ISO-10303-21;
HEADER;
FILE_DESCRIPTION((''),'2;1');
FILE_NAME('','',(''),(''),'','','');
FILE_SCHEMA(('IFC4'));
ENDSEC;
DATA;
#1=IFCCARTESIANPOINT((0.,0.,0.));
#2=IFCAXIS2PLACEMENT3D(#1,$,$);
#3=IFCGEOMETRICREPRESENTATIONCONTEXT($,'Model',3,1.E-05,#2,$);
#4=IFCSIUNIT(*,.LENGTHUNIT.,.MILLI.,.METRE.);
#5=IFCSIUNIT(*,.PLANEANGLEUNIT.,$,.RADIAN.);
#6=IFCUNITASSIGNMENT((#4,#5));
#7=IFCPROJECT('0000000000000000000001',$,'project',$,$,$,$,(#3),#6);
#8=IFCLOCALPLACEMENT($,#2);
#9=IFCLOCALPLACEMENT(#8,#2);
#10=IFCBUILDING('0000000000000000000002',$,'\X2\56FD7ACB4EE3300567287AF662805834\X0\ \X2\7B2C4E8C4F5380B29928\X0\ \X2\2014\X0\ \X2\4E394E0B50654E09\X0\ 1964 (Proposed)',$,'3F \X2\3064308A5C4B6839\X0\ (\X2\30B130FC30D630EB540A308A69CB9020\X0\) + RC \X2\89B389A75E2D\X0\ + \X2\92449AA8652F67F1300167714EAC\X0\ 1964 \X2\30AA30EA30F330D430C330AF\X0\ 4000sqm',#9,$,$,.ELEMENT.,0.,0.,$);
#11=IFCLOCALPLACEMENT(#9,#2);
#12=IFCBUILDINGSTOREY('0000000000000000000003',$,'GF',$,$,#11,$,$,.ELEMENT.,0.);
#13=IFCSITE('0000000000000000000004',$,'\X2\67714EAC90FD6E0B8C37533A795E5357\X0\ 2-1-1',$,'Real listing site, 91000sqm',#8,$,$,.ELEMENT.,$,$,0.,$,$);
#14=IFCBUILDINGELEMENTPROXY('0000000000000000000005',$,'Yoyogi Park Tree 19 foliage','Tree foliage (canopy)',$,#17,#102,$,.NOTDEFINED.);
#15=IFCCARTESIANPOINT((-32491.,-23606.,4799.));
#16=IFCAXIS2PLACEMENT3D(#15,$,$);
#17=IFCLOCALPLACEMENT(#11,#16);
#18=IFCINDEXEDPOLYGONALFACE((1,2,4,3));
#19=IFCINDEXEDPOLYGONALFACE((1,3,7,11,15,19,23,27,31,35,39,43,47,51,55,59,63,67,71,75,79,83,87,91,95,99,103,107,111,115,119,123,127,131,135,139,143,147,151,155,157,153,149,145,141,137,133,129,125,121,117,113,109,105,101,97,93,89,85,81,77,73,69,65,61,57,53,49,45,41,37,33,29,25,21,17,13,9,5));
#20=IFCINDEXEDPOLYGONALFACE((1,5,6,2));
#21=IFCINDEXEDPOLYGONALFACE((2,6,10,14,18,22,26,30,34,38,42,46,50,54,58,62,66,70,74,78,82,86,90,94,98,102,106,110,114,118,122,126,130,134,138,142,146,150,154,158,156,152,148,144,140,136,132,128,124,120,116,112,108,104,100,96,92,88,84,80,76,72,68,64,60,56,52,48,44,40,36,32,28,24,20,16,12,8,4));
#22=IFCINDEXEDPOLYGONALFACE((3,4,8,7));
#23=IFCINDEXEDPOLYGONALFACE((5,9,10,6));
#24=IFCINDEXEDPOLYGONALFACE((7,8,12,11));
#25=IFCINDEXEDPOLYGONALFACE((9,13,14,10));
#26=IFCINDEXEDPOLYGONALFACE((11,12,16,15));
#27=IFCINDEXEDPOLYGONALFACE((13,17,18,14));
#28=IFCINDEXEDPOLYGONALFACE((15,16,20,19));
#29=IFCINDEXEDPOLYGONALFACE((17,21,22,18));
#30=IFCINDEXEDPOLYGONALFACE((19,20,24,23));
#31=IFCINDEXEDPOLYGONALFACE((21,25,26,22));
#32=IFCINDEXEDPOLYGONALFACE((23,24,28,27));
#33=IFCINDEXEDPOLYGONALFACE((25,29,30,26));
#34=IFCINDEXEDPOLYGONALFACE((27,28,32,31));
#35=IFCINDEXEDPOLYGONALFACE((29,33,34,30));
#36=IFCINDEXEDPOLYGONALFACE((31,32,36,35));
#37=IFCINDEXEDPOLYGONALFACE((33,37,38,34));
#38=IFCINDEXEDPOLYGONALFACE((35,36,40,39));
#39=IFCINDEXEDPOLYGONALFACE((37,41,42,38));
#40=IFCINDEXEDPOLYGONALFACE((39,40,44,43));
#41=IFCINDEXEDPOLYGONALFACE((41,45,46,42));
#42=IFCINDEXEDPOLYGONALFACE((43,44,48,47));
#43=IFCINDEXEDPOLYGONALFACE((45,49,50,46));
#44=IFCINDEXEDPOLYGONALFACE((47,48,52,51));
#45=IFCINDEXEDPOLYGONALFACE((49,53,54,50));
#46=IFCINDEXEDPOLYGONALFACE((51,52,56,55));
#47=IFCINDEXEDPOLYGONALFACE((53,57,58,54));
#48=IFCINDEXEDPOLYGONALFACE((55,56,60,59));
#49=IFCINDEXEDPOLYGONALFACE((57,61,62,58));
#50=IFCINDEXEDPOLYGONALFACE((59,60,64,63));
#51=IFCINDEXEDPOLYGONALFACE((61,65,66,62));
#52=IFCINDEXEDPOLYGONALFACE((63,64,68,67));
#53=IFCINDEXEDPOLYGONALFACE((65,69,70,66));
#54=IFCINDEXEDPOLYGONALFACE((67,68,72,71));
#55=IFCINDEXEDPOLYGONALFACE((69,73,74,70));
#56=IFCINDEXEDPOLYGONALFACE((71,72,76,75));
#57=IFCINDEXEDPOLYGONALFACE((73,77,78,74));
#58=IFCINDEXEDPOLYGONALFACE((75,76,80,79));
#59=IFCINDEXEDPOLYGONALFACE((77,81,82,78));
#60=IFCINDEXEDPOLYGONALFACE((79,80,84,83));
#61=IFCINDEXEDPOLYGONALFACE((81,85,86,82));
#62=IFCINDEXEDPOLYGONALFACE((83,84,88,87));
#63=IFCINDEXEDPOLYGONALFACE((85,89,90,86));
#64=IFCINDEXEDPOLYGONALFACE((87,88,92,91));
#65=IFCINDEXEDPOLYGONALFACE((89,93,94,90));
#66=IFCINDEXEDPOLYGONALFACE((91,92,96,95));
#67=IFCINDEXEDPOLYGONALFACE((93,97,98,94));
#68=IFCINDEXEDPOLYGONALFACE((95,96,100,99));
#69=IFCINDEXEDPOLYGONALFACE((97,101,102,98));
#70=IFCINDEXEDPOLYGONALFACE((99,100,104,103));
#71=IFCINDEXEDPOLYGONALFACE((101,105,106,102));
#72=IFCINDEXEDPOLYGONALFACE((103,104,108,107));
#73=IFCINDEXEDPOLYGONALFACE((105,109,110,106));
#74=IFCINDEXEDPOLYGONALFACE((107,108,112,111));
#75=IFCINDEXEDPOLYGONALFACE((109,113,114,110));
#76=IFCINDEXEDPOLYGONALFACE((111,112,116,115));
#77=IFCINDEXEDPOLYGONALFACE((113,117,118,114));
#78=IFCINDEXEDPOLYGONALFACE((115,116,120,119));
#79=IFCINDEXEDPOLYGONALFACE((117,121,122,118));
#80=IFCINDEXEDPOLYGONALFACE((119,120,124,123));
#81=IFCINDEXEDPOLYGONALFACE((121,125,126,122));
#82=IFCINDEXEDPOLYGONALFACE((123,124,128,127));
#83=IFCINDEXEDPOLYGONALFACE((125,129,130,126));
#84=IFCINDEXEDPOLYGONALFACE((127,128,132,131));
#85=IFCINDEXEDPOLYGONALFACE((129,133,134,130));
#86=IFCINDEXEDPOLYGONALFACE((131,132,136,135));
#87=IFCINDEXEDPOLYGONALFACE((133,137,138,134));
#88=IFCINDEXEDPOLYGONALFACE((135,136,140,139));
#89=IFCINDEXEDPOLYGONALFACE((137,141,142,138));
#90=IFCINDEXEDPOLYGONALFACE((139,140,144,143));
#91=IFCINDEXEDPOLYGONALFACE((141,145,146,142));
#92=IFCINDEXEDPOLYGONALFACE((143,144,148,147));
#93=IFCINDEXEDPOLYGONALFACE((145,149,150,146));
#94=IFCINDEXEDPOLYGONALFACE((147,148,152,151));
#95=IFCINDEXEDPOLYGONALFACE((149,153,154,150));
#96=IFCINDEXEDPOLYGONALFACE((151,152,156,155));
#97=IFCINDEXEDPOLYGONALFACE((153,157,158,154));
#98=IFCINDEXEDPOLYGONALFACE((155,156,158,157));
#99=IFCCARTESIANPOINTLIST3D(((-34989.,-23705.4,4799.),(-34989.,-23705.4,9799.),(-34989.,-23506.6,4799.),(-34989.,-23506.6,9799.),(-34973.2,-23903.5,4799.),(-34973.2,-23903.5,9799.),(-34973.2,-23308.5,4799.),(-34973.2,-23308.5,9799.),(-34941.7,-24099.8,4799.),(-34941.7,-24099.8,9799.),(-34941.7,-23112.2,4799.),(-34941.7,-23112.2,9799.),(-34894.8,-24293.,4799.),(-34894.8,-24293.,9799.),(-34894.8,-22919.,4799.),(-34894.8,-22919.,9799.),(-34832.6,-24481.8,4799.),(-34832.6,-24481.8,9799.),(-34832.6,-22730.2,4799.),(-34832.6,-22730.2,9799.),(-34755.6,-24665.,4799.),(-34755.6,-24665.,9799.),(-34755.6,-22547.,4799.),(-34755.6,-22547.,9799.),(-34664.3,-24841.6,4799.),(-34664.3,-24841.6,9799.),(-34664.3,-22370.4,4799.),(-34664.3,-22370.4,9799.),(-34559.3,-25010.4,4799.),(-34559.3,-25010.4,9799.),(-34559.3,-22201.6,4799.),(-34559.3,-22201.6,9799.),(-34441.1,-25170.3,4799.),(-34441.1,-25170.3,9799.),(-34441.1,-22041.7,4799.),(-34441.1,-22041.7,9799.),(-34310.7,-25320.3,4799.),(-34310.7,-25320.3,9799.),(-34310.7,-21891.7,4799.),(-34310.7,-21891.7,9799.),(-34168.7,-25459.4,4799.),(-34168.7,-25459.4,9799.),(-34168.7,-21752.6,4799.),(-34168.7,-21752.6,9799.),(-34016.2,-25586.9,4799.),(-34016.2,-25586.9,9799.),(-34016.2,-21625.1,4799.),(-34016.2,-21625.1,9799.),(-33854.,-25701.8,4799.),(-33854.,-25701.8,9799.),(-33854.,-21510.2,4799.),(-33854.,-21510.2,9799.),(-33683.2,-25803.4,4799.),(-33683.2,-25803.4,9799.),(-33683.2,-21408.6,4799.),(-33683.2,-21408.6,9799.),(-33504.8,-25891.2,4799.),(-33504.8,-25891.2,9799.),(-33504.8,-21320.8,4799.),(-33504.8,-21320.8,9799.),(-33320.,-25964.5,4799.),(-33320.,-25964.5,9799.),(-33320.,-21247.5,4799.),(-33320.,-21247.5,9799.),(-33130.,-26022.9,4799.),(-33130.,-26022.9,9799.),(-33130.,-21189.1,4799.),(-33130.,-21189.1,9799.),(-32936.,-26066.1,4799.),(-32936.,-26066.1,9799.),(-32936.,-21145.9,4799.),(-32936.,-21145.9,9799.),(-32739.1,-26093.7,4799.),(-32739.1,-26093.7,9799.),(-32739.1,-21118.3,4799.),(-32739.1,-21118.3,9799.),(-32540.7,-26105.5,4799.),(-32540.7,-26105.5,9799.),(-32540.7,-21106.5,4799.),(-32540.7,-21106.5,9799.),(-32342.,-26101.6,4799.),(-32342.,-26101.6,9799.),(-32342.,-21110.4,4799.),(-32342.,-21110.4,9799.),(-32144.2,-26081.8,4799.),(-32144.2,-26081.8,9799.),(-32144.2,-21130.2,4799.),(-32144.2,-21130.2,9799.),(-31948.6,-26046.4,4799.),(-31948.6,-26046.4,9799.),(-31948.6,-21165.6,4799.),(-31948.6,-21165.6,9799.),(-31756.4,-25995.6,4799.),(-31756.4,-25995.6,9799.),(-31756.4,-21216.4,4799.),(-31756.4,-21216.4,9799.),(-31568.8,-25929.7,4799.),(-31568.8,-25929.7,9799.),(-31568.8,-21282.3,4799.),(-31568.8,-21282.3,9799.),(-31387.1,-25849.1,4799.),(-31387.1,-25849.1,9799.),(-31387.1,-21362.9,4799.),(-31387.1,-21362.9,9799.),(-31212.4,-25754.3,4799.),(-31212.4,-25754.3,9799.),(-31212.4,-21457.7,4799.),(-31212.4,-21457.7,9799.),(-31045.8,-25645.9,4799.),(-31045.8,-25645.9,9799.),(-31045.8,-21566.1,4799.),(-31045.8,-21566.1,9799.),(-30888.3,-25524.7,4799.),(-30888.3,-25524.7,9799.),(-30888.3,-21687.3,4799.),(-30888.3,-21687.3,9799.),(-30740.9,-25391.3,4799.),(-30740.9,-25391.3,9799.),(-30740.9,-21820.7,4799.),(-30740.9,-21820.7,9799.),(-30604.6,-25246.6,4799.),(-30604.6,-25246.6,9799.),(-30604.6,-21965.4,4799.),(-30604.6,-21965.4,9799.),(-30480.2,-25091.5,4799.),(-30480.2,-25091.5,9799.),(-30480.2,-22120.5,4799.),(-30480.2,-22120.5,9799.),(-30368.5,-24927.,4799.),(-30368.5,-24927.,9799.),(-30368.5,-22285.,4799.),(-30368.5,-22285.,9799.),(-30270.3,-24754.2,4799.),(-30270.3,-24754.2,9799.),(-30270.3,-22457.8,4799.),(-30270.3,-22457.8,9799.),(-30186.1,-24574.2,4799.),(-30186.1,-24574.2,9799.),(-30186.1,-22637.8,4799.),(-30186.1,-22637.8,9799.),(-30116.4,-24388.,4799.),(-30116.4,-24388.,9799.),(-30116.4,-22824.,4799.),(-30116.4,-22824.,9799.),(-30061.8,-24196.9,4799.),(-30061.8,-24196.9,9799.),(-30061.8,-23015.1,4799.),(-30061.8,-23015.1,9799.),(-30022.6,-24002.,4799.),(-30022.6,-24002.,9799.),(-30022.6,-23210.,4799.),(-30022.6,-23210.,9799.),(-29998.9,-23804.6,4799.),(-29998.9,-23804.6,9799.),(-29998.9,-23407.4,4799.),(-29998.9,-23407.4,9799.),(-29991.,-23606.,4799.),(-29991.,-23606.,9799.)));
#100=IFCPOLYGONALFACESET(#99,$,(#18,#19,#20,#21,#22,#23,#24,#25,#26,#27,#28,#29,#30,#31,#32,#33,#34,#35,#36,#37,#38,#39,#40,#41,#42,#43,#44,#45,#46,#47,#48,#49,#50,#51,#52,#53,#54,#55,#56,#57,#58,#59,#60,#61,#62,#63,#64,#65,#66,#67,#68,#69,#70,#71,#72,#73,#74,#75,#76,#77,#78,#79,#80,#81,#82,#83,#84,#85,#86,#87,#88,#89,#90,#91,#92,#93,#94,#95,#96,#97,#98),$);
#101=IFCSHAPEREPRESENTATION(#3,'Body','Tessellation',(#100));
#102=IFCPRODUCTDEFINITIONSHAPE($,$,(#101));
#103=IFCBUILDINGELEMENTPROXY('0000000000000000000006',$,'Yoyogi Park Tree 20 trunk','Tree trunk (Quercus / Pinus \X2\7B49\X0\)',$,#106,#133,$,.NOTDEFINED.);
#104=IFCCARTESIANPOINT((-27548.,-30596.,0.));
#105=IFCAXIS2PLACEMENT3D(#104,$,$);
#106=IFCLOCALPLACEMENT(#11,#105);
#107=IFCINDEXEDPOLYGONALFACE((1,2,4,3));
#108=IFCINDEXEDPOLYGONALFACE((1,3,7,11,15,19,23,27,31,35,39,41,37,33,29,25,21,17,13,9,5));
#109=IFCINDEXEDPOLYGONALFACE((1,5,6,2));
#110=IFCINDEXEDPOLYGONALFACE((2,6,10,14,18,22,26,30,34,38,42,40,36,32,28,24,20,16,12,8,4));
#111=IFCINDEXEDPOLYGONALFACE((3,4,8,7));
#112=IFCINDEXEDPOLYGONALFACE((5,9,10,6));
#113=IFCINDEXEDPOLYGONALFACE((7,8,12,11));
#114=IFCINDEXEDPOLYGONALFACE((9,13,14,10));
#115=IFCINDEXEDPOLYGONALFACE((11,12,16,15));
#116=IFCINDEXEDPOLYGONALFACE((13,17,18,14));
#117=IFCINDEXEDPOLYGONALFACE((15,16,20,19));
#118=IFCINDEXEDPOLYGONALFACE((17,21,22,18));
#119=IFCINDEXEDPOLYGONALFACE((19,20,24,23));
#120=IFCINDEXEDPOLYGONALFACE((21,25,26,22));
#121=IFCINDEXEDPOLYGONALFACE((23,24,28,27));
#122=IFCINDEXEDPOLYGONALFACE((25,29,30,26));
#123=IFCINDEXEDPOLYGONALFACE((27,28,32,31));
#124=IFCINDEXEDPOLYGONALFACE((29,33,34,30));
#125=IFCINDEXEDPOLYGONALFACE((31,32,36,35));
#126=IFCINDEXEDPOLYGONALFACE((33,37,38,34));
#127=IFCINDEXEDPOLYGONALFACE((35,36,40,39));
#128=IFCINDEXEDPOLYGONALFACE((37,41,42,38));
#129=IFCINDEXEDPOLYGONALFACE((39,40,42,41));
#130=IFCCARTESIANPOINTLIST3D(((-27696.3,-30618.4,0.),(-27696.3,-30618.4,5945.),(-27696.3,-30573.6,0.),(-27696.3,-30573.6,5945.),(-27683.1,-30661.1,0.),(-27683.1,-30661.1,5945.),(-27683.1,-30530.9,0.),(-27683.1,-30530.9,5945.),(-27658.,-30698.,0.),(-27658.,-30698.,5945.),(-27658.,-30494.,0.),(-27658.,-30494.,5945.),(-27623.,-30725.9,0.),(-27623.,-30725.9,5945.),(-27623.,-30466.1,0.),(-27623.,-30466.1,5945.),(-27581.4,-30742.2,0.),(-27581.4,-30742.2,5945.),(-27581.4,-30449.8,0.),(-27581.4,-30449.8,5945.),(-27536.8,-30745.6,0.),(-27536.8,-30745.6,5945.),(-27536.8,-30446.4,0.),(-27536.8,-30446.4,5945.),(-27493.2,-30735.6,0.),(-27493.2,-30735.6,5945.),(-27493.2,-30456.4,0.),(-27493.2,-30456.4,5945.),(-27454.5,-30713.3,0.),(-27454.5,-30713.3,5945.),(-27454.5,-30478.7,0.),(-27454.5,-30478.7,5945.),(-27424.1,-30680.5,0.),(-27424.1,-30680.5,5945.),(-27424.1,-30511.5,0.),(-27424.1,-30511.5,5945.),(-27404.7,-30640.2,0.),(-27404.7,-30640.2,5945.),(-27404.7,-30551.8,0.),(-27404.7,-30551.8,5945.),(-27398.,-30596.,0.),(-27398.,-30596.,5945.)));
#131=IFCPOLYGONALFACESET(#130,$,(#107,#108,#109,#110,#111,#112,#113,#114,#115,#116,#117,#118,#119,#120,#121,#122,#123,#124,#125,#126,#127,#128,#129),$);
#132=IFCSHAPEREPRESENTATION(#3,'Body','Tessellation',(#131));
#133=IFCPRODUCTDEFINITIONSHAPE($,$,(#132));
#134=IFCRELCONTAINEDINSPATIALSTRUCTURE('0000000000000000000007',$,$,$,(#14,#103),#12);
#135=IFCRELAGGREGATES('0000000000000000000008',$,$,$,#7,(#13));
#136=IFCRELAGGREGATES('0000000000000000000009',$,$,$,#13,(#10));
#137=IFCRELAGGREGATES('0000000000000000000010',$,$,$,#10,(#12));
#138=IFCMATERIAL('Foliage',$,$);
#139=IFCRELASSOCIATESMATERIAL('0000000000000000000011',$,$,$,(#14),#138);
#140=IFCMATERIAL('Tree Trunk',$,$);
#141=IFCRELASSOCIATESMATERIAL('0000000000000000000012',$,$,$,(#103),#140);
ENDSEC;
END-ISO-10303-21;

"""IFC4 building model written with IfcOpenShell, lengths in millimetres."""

from ifc_helpers import new_model, si_unit, frame, origin, origin_2d, place, context, project, spatial, circle, extrude, material, element, save


model = new_model("IFC4")

# Units and contexts
model_context = context("Model", 3, precision=1e-05, world=origin())
ifc_project = project(units=[si_unit("LENGTHUNIT", "METRE", prefix="MILLI"), si_unit("PLANEANGLEUNIT", "RADIAN")], contexts=[model_context])

# Site, building, storey
site_placement = place(None, origin())
site = spatial("IfcSite", under=ifc_project, at=site_placement, Name="東京都渋谷区神南 2-1-1", ObjectType="Real listing site, 91000sqm", CompositionType="ELEMENT", RefElevation=0.0)
building_placement = place(site_placement, origin())
building = spatial("IfcBuilding", under=site, at=building_placement, Name="国立代々木競技場 第二体育館 — 丹下健三 1964 (Proposed)", ObjectType="3F つり屋根 (ケーブル吊り構造) + RC 観覧席 + 鉄骨支柱、東京 1964 オリンピック 4000sqm", CompositionType="ELEMENT", ElevationOfRefHeight=0.0, ElevationOfTerrain=0.0)
storey_placement = place(building_placement, origin())
storey = spatial("IfcBuildingStorey", under=building, at=storey_placement, Name="GF", CompositionType="ELEMENT", Elevation=0.0)

# Building element proxies
ifc_material_1 = material(Name="Tree Trunk")
ifc_material_2 = material(Name="Foliage")
proxy_1_placement = place(storey_placement, frame((-32491.0, -23606.0, 4799.0)))
element("IfcBuildingElementProxy", 1, at=proxy_1_placement, inside=storey, material=ifc_material_2, Name="Yoyogi Park Tree 19 foliage", Description="Tree foliage (canopy)", PredefinedType="NOTDEFINED", context=model_context, shape_type="SweptSolid", body=[
    extrude(circle(Radius=2500.0, at=origin_2d()), frame((-32491.0, -23606.0, 4799.0)), (0.0, 0.0, 1.0), 5000.0),
])
proxy_2_placement = place(storey_placement, frame((-27548.0, -30596.0, 0.0)))
element("IfcBuildingElementProxy", 2, at=proxy_2_placement, inside=storey, material=ifc_material_1, Name="Yoyogi Park Tree 20 trunk", Description="Tree trunk (Quercus / Pinus 等)", PredefinedType="NOTDEFINED", context=model_context, shape_type="SweptSolid", body=[
    extrude(circle(Radius=150.0, at=origin_2d()), frame((-27548.0, -30596.0, 0.0)), (0.0, 0.0, 1.0), 5945.0),
])

save(model, "model.ifc")
